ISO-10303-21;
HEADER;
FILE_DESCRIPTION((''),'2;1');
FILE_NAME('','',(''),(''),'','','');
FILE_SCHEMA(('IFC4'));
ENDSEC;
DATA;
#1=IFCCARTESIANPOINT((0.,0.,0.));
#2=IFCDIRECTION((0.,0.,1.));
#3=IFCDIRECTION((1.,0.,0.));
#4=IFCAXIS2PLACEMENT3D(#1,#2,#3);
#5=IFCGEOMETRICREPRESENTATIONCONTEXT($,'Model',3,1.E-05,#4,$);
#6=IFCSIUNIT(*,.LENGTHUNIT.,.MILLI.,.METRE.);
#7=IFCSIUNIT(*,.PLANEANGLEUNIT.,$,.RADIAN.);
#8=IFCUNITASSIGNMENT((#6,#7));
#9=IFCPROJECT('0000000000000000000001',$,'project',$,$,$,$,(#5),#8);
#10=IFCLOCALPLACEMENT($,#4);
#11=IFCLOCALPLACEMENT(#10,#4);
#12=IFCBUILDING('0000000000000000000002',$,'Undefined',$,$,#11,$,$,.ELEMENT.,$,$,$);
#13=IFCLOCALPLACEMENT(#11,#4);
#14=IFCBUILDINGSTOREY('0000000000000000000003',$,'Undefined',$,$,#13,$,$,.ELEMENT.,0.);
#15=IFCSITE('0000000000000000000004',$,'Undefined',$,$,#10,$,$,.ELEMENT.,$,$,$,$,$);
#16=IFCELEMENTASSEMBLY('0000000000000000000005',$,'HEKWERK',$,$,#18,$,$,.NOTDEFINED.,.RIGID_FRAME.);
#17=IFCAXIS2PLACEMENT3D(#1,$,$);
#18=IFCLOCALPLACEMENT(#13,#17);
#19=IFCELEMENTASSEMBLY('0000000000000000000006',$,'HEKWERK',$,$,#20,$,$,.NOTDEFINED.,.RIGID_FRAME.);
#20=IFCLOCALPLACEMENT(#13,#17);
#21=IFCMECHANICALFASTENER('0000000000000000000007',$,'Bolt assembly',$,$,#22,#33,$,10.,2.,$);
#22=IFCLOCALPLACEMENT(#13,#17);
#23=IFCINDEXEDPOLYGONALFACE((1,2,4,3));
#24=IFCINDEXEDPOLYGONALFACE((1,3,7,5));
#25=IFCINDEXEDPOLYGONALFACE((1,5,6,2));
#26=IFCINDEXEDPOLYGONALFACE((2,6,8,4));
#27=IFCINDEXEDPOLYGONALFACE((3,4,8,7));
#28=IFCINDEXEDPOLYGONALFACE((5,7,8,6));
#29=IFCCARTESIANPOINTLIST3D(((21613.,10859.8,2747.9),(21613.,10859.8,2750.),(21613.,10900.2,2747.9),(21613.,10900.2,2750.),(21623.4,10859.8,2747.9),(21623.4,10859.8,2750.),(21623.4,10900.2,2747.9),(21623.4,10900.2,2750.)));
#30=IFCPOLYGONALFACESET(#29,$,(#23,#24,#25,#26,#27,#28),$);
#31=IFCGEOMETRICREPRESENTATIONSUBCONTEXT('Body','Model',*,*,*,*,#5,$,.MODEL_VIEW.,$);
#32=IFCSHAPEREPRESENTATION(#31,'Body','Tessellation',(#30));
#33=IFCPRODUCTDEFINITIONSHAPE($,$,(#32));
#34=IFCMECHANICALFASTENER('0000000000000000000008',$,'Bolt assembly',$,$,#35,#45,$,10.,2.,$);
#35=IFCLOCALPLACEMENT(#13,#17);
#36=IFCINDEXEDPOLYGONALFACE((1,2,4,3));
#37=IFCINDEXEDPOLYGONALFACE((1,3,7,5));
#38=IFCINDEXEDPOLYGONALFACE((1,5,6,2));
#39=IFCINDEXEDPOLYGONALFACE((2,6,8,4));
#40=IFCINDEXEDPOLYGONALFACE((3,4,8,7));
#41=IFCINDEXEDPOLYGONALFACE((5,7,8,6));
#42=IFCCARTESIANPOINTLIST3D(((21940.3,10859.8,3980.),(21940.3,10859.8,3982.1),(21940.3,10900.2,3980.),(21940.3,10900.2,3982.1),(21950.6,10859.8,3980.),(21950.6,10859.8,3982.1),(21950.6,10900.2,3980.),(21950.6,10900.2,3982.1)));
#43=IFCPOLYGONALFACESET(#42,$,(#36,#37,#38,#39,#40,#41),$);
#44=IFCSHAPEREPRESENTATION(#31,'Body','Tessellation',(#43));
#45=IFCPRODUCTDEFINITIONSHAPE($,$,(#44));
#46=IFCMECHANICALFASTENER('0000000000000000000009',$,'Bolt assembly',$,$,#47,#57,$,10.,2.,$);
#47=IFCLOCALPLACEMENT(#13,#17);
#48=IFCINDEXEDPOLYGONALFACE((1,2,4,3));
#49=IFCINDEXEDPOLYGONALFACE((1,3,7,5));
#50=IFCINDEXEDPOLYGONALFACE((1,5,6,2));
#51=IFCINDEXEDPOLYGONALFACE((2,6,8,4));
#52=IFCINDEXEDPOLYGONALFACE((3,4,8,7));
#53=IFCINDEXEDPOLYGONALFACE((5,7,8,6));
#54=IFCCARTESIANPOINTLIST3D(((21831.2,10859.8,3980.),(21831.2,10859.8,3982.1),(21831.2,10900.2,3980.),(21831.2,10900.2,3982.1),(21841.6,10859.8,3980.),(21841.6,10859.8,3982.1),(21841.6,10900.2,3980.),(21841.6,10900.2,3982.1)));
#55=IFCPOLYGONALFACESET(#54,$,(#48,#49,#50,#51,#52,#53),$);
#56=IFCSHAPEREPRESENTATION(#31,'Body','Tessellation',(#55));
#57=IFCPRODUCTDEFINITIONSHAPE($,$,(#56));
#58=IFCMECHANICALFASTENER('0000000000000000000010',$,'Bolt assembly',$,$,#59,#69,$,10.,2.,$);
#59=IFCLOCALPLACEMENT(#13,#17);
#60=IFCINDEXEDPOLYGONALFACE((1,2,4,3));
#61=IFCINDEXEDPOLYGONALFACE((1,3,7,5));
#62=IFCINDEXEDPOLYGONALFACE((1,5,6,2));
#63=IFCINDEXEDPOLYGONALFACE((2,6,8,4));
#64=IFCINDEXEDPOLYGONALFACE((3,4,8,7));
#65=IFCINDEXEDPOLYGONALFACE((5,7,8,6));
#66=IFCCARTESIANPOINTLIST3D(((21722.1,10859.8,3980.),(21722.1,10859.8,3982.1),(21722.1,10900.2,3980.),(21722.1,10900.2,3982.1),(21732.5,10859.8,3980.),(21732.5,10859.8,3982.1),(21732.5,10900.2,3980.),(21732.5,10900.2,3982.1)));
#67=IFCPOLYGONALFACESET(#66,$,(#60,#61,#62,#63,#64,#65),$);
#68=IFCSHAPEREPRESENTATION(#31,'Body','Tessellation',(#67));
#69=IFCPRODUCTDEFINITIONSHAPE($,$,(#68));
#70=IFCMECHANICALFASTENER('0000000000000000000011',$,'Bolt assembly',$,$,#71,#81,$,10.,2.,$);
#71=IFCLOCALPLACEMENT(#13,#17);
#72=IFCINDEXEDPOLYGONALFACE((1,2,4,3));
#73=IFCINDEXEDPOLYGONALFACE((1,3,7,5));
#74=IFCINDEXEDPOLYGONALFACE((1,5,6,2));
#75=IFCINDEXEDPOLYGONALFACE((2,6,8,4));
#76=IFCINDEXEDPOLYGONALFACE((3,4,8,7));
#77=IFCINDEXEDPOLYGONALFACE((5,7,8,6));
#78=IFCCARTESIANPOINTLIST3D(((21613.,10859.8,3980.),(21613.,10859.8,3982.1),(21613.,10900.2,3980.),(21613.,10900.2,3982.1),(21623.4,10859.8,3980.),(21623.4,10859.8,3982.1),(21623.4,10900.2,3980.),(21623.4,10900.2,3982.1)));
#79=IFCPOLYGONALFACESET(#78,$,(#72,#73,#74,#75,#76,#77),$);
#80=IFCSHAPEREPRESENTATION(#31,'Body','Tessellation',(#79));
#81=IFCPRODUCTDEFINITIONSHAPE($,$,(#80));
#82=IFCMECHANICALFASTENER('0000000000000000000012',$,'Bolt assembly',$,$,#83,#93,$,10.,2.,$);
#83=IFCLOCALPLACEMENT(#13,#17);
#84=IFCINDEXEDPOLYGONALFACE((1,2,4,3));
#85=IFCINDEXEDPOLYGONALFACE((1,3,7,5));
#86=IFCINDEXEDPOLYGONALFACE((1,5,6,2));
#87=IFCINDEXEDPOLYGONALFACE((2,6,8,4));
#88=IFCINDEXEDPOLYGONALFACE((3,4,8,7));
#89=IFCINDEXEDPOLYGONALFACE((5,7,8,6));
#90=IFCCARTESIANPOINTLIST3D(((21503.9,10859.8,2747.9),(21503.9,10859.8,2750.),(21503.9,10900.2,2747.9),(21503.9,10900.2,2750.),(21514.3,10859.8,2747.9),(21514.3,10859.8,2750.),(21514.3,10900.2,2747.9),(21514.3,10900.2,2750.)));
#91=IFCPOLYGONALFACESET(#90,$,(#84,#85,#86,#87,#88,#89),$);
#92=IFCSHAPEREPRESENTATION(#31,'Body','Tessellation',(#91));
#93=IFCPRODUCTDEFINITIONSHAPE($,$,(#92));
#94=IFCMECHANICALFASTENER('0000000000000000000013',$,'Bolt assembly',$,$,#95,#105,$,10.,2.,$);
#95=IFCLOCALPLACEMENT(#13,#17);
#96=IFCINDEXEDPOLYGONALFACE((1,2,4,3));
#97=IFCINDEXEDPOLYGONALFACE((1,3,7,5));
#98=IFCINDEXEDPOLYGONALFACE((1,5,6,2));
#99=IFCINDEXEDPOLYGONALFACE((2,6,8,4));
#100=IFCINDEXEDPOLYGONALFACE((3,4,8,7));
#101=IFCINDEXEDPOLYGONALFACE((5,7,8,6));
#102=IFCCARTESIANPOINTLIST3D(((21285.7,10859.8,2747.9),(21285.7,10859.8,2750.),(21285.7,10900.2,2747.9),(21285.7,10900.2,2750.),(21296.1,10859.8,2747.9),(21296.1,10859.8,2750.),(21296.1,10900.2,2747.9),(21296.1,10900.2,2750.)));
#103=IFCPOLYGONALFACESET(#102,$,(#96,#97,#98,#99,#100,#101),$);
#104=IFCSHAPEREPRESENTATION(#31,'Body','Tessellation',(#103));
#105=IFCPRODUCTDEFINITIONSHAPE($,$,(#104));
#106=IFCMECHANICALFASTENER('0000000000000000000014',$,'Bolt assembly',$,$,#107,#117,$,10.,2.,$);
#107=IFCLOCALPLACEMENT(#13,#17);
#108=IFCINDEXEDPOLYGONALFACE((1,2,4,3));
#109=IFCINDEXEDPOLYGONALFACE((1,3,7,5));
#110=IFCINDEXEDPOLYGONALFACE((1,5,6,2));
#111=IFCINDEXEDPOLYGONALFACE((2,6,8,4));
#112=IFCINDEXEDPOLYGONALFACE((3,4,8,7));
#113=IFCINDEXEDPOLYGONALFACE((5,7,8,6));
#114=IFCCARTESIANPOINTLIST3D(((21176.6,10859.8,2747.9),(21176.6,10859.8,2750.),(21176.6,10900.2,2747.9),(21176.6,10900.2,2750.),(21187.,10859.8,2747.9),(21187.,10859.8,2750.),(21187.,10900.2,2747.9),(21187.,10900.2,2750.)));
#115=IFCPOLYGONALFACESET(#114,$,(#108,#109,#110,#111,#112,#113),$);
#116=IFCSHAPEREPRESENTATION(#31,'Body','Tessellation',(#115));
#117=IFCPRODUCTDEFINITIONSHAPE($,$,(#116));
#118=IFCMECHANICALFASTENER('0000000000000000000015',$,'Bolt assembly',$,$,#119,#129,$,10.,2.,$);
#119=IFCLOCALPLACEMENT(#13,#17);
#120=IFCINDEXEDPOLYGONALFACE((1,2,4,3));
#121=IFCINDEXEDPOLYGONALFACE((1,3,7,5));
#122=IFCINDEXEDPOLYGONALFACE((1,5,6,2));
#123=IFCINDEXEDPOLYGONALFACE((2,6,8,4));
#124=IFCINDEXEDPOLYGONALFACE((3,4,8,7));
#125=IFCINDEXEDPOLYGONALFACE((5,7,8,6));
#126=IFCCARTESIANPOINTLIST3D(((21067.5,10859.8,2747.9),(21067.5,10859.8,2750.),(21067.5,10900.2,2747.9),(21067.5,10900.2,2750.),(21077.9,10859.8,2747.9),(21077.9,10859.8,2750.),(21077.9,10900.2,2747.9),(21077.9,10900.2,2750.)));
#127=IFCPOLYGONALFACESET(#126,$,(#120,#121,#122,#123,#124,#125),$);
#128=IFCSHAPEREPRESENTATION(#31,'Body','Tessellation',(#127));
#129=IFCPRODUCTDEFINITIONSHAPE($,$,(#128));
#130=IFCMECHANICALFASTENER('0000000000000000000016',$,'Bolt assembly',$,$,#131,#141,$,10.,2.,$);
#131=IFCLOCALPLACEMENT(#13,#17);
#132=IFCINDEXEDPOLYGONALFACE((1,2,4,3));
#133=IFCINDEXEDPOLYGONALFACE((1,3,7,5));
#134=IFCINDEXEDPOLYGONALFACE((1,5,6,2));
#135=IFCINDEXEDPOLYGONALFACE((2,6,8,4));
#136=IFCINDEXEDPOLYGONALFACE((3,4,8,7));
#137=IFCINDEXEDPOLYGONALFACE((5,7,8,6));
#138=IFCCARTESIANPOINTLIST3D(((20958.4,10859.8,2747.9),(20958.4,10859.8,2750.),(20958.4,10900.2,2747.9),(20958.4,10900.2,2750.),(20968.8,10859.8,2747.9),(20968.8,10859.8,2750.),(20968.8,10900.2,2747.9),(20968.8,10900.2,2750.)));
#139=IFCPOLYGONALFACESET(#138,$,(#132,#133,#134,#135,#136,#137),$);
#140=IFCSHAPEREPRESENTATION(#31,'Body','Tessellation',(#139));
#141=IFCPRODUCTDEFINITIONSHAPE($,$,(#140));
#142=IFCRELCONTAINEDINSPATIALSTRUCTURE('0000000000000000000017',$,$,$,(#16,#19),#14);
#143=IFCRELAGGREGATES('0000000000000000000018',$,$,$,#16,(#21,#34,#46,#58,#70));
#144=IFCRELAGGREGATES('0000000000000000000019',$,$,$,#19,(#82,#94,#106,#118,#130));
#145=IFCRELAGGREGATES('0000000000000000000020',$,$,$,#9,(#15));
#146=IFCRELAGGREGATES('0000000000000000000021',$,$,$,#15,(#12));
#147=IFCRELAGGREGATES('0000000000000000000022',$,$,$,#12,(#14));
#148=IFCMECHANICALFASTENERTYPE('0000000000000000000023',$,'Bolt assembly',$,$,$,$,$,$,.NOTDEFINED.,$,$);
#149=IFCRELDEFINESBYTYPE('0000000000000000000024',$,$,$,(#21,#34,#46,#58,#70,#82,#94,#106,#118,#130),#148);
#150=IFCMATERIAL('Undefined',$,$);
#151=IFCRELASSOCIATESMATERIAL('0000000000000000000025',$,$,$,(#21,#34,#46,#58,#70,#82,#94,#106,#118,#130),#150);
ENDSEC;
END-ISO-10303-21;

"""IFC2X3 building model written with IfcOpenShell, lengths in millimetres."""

from ifc_helpers import new_model, si_unit, frame, origin_with_axes, place, context, subcontext, project, spatial, polyline, segment, composite_curve, outline, extrude, source, transform, mapped, material, type_object, element, aggregate, save


model = new_model("IFC2X3")

# Units and contexts
model_context = context("Model", 3, precision=1e-05, world=origin_with_axes())
body_context = subcontext(model_context, "Body", "Model", "MODEL_VIEW")
ifc_project = project(units=[si_unit("LENGTHUNIT", "METRE", prefix="MILLI"), si_unit("PLANEANGLEUNIT", "RADIAN")], contexts=[model_context])

# Site, building, storey
site_placement = place(None, origin_with_axes())
site = spatial("IfcSite", under=ifc_project, at=site_placement, Name="Undefined", CompositionType="ELEMENT")
building_placement = place(site_placement, origin_with_axes())
building = spatial("IfcBuilding", under=site, at=building_placement, Name="Undefined", CompositionType="ELEMENT")
storey_placement = place(building_placement, origin_with_axes())
storey = spatial("IfcBuildingStorey", under=building, at=storey_placement, Name="Undefined", CompositionType="ELEMENT", Elevation=0.0)

# Element assemblies
assembly_1_placement = place(storey_placement, origin_with_axes())
assembly_1 = element("IfcElementAssembly", 1, at=assembly_1_placement, inside=storey, Name="HEKWERK", AssemblyPlace="NOTDEFINED", PredefinedType="RIGID_FRAME")
assembly_2_placement = place(storey_placement, origin_with_axes())
assembly_2 = element("IfcElementAssembly", 2, at=assembly_2_placement, inside=storey, Name="HEKWERK", AssemblyPlace="NOTDEFINED", PredefinedType="RIGID_FRAME")

# Mechanical fasteners
ifc_material_1 = material(Name="Undefined")
mechanical_fastener_type = type_object("IfcMechanicalFastenerType", Name="Bolt assembly")
shared_shape_1 = source(origin_with_axes(), body_context, "Body", "SweptSolid", [
    extrude(outline(composite_curve([segment(polyline([(-20.2, 5.2), (20.2, 5.2)]), True, "CONTINUOUS"), segment(polyline([(20.2, 5.2), (20.2, -5.2)]), True, "CONTINUOUS"), segment(polyline([(20.2, -5.2), (-20.2, -5.2)]), True, "CONTINUOUS"), segment(polyline([(-20.2, -5.2), (-20.2, 5.2)]), True, "CONTINUOUS")], self_intersect=False)), frame((0.0, -1.0, 0.0), z_axis=(0.0, 1.0, 0.0), x_axis=(1.0, 0.0, 0.0)), (0.0, 0.0, 1.0), 2.1),
])
mechanical_fastener_1_placement = place(assembly_1_placement, frame((21618.2, 10880.0, 2749.0), z_axis=(1.0, 0.0, 0.0), x_axis=(0.0, -1.0, 0.0)))
mechanical_fastener_1 = element("IfcMechanicalFastener", 3, at=mechanical_fastener_1_placement, type_object=mechanical_fastener_type, material=ifc_material_1, Name="Bolt assembly", NominalDiameter=10.0, NominalLength=2.0, context=body_context, shape_type="MappedRepresentation", body=[
    mapped(shared_shape_1, transform((0.0, 0.0, 0.0))),
])
shared_shape_2 = source(origin_with_axes(), body_context, "Body", "SweptSolid", [
    extrude(outline(composite_curve([segment(polyline([(-20.2, 5.2), (20.2, 5.2)]), True, "CONTINUOUS"), segment(polyline([(20.2, 5.2), (20.2, -5.2)]), True, "CONTINUOUS"), segment(polyline([(20.2, -5.2), (-20.2, -5.2)]), True, "CONTINUOUS"), segment(polyline([(-20.2, -5.2), (-20.2, 5.2)]), True, "CONTINUOUS")], self_intersect=False)), frame((0.0, -1.0, 0.0), z_axis=(0.0, 1.0, 0.0), x_axis=(1.0, 0.0, 0.0)), (0.0, 0.0, 1.0), 2.1),
])
mechanical_fastener_2_placement = place(assembly_1_placement, frame((21945.4, 10880.0, 3981.0), z_axis=(-1.0, 0.0, 0.0), x_axis=(0.0, -1.0, 0.0)))
mechanical_fastener_2 = element("IfcMechanicalFastener", 4, at=mechanical_fastener_2_placement, type_object=mechanical_fastener_type, material=ifc_material_1, Name="Bolt assembly", NominalDiameter=10.0, NominalLength=2.0, context=body_context, shape_type="MappedRepresentation", body=[
    mapped(shared_shape_2, transform((0.0, 0.0, 0.0))),
])
shared_shape_3 = source(origin_with_axes(), body_context, "Body", "SweptSolid", [
    extrude(outline(composite_curve([segment(polyline([(-20.2, 5.2), (20.2, 5.2)]), True, "CONTINUOUS"), segment(polyline([(20.2, 5.2), (20.2, -5.2)]), True, "CONTINUOUS"), segment(polyline([(20.2, -5.2), (-20.2, -5.2)]), True, "CONTINUOUS"), segment(polyline([(-20.2, -5.2), (-20.2, 5.2)]), True, "CONTINUOUS")], self_intersect=False)), frame((0.0, -1.0, 0.0), z_axis=(0.0, 1.0, 0.0), x_axis=(1.0, 0.0, 0.0)), (0.0, 0.0, 1.0), 2.1),
])
mechanical_fastener_3_placement = place(assembly_1_placement, frame((21836.4, 10880.0, 3981.0), z_axis=(-1.0, 0.0, 0.0), x_axis=(0.0, -1.0, 0.0)))
mechanical_fastener_3 = element("IfcMechanicalFastener", 5, at=mechanical_fastener_3_placement, type_object=mechanical_fastener_type, material=ifc_material_1, Name="Bolt assembly", NominalDiameter=10.0, NominalLength=2.0, context=body_context, shape_type="MappedRepresentation", body=[
    mapped(shared_shape_3, transform((0.0, 0.0, 0.0))),
])
shared_shape_4 = source(origin_with_axes(), body_context, "Body", "SweptSolid", [
    extrude(outline(composite_curve([segment(polyline([(-20.2, 5.2), (20.2, 5.2)]), True, "CONTINUOUS"), segment(polyline([(20.2, 5.2), (20.2, -5.2)]), True, "CONTINUOUS"), segment(polyline([(20.2, -5.2), (-20.2, -5.2)]), True, "CONTINUOUS"), segment(polyline([(-20.2, -5.2), (-20.2, 5.2)]), True, "CONTINUOUS")], self_intersect=False)), frame((0.0, -1.0, 0.0), z_axis=(0.0, 1.0, 0.0), x_axis=(1.0, 0.0, 0.0)), (0.0, 0.0, 1.0), 2.1),
])
mechanical_fastener_4_placement = place(assembly_1_placement, frame((21727.3, 10880.0, 3981.0), z_axis=(-1.0, 0.0, 0.0), x_axis=(0.0, -1.0, 0.0)))
mechanical_fastener_4 = element("IfcMechanicalFastener", 6, at=mechanical_fastener_4_placement, type_object=mechanical_fastener_type, material=ifc_material_1, Name="Bolt assembly", NominalDiameter=10.0, NominalLength=2.0, context=body_context, shape_type="MappedRepresentation", body=[
    mapped(shared_shape_4, transform((0.0, 0.0, 0.0))),
])
shared_shape_5 = source(origin_with_axes(), body_context, "Body", "SweptSolid", [
    extrude(outline(composite_curve([segment(polyline([(-20.2, 5.2), (20.2, 5.2)]), True, "CONTINUOUS"), segment(polyline([(20.2, 5.2), (20.2, -5.2)]), True, "CONTINUOUS"), segment(polyline([(20.2, -5.2), (-20.2, -5.2)]), True, "CONTINUOUS"), segment(polyline([(-20.2, -5.2), (-20.2, 5.2)]), True, "CONTINUOUS")], self_intersect=False)), frame((0.0, -1.0, 0.0), z_axis=(0.0, 1.0, 0.0), x_axis=(1.0, 0.0, 0.0)), (0.0, 0.0, 1.0), 2.1),
])
mechanical_fastener_5_placement = place(assembly_1_placement, frame((21618.2, 10880.0, 3981.0), z_axis=(-1.0, 0.0, 0.0), x_axis=(0.0, -1.0, 0.0)))
mechanical_fastener_5 = element("IfcMechanicalFastener", 7, at=mechanical_fastener_5_placement, type_object=mechanical_fastener_type, material=ifc_material_1, Name="Bolt assembly", NominalDiameter=10.0, NominalLength=2.0, context=body_context, shape_type="MappedRepresentation", body=[
    mapped(shared_shape_5, transform((0.0, 0.0, 0.0))),
])
aggregate(assembly_1, [mechanical_fastener_1, mechanical_fastener_2, mechanical_fastener_3, mechanical_fastener_4, mechanical_fastener_5])
shared_shape_6 = source(origin_with_axes(), body_context, "Body", "SweptSolid", [
    extrude(outline(composite_curve([segment(polyline([(-20.2, 5.2), (20.2, 5.2)]), True, "CONTINUOUS"), segment(polyline([(20.2, 5.2), (20.2, -5.2)]), True, "CONTINUOUS"), segment(polyline([(20.2, -5.2), (-20.2, -5.2)]), True, "CONTINUOUS"), segment(polyline([(-20.2, -5.2), (-20.2, 5.2)]), True, "CONTINUOUS")], self_intersect=False)), frame((0.0, -1.0, 0.0), z_axis=(0.0, 1.0, 0.0), x_axis=(1.0, 0.0, 0.0)), (0.0, 0.0, 1.0), 2.1),
])
mechanical_fastener_6_placement = place(assembly_2_placement, frame((21509.1, 10880.0, 2749.0), z_axis=(1.0, 0.0, 0.0), x_axis=(0.0, -1.0, 0.0)))
mechanical_fastener_6 = element("IfcMechanicalFastener", 8, at=mechanical_fastener_6_placement, type_object=mechanical_fastener_type, material=ifc_material_1, Name="Bolt assembly", NominalDiameter=10.0, NominalLength=2.0, context=body_context, shape_type="MappedRepresentation", body=[
    mapped(shared_shape_6, transform((0.0, 0.0, 0.0))),
])
shared_shape_7 = source(origin_with_axes(), body_context, "Body", "SweptSolid", [
    extrude(outline(composite_curve([segment(polyline([(-20.2, 5.2), (20.2, 5.2)]), True, "CONTINUOUS"), segment(polyline([(20.2, 5.2), (20.2, -5.2)]), True, "CONTINUOUS"), segment(polyline([(20.2, -5.2), (-20.2, -5.2)]), True, "CONTINUOUS"), segment(polyline([(-20.2, -5.2), (-20.2, 5.2)]), True, "CONTINUOUS")], self_intersect=False)), frame((0.0, -1.0, 0.0), z_axis=(0.0, 1.0, 0.0), x_axis=(1.0, 0.0, 0.0)), (0.0, 0.0, 1.0), 2.1),
])
mechanical_fastener_7_placement = place(assembly_2_placement, frame((21290.9, 10880.0, 2749.0), z_axis=(1.0, 0.0, 0.0), x_axis=(0.0, -1.0, 0.0)))
mechanical_fastener_7 = element("IfcMechanicalFastener", 9, at=mechanical_fastener_7_placement, type_object=mechanical_fastener_type, material=ifc_material_1, Name="Bolt assembly", NominalDiameter=10.0, NominalLength=2.0, context=body_context, shape_type="MappedRepresentation", body=[
    mapped(shared_shape_7, transform((0.0, 0.0, 0.0))),
])
shared_shape_8 = source(origin_with_axes(), body_context, "Body", "SweptSolid", [
    extrude(outline(composite_curve([segment(polyline([(-20.2, 5.2), (20.2, 5.2)]), True, "CONTINUOUS"), segment(polyline([(20.2, 5.2), (20.2, -5.2)]), True, "CONTINUOUS"), segment(polyline([(20.2, -5.2), (-20.2, -5.2)]), True, "CONTINUOUS"), segment(polyline([(-20.2, -5.2), (-20.2, 5.2)]), True, "CONTINUOUS")], self_intersect=False)), frame((0.0, -1.0, 0.0), z_axis=(0.0, 1.0, 0.0), x_axis=(1.0, 0.0, 0.0)), (0.0, 0.0, 1.0), 2.1),
])
mechanical_fastener_8_placement = place(assembly_2_placement, frame((21181.8, 10880.0, 2749.0), z_axis=(1.0, 0.0, 0.0), x_axis=(0.0, -1.0, 0.0)))
mechanical_fastener_8 = element("IfcMechanicalFastener", 10, at=mechanical_fastener_8_placement, type_object=mechanical_fastener_type, material=ifc_material_1, Name="Bolt assembly", NominalDiameter=10.0, NominalLength=2.0, context=body_context, shape_type="MappedRepresentation", body=[
    mapped(shared_shape_8, transform((0.0, 0.0, 0.0))),
])
shared_shape_9 = source(origin_with_axes(), body_context, "Body", "SweptSolid", [
    extrude(outline(composite_curve([segment(polyline([(-20.2, 5.2), (20.2, 5.2)]), True, "CONTINUOUS"), segment(polyline([(20.2, 5.2), (20.2, -5.2)]), True, "CONTINUOUS"), segment(polyline([(20.2, -5.2), (-20.2, -5.2)]), True, "CONTINUOUS"), segment(polyline([(-20.2, -5.2), (-20.2, 5.2)]), True, "CONTINUOUS")], self_intersect=False)), frame((0.0, -1.0, 0.0), z_axis=(0.0, 1.0, 0.0), x_axis=(1.0, 0.0, 0.0)), (0.0, 0.0, 1.0), 2.1),
])
mechanical_fastener_9_placement = place(assembly_2_placement, frame((21072.7, 10880.0, 2749.0), z_axis=(1.0, 0.0, 0.0), x_axis=(0.0, -1.0, 0.0)))
mechanical_fastener_9 = element("IfcMechanicalFastener", 11, at=mechanical_fastener_9_placement, type_object=mechanical_fastener_type, material=ifc_material_1, Name="Bolt assembly", NominalDiameter=10.0, NominalLength=2.0, context=body_context, shape_type="MappedRepresentation", body=[
    mapped(shared_shape_9, transform((0.0, 0.0, 0.0))),
])
shared_shape_10 = source(origin_with_axes(), body_context, "Body", "SweptSolid", [
    extrude(outline(composite_curve([segment(polyline([(-20.2, 5.2), (20.2, 5.2)]), True, "CONTINUOUS"), segment(polyline([(20.2, 5.2), (20.2, -5.2)]), True, "CONTINUOUS"), segment(polyline([(20.2, -5.2), (-20.2, -5.2)]), True, "CONTINUOUS"), segment(polyline([(-20.2, -5.2), (-20.2, 5.2)]), True, "CONTINUOUS")], self_intersect=False)), frame((0.0, -1.0, 0.0), z_axis=(0.0, 1.0, 0.0), x_axis=(1.0, 0.0, 0.0)), (0.0, 0.0, 1.0), 2.1),
])
mechanical_fastener_10_placement = place(assembly_2_placement, frame((20963.6, 10880.0, 2749.0), z_axis=(1.0, 0.0, 0.0), x_axis=(0.0, -1.0, 0.0)))
mechanical_fastener_10 = element("IfcMechanicalFastener", 12, at=mechanical_fastener_10_placement, type_object=mechanical_fastener_type, material=ifc_material_1, Name="Bolt assembly", NominalDiameter=10.0, NominalLength=2.0, context=body_context, shape_type="MappedRepresentation", body=[
    mapped(shared_shape_10, transform((0.0, 0.0, 0.0))),
])
aggregate(assembly_2, [mechanical_fastener_6, mechanical_fastener_7, mechanical_fastener_8, mechanical_fastener_9, mechanical_fastener_10])

save(model, "model.ifc")
